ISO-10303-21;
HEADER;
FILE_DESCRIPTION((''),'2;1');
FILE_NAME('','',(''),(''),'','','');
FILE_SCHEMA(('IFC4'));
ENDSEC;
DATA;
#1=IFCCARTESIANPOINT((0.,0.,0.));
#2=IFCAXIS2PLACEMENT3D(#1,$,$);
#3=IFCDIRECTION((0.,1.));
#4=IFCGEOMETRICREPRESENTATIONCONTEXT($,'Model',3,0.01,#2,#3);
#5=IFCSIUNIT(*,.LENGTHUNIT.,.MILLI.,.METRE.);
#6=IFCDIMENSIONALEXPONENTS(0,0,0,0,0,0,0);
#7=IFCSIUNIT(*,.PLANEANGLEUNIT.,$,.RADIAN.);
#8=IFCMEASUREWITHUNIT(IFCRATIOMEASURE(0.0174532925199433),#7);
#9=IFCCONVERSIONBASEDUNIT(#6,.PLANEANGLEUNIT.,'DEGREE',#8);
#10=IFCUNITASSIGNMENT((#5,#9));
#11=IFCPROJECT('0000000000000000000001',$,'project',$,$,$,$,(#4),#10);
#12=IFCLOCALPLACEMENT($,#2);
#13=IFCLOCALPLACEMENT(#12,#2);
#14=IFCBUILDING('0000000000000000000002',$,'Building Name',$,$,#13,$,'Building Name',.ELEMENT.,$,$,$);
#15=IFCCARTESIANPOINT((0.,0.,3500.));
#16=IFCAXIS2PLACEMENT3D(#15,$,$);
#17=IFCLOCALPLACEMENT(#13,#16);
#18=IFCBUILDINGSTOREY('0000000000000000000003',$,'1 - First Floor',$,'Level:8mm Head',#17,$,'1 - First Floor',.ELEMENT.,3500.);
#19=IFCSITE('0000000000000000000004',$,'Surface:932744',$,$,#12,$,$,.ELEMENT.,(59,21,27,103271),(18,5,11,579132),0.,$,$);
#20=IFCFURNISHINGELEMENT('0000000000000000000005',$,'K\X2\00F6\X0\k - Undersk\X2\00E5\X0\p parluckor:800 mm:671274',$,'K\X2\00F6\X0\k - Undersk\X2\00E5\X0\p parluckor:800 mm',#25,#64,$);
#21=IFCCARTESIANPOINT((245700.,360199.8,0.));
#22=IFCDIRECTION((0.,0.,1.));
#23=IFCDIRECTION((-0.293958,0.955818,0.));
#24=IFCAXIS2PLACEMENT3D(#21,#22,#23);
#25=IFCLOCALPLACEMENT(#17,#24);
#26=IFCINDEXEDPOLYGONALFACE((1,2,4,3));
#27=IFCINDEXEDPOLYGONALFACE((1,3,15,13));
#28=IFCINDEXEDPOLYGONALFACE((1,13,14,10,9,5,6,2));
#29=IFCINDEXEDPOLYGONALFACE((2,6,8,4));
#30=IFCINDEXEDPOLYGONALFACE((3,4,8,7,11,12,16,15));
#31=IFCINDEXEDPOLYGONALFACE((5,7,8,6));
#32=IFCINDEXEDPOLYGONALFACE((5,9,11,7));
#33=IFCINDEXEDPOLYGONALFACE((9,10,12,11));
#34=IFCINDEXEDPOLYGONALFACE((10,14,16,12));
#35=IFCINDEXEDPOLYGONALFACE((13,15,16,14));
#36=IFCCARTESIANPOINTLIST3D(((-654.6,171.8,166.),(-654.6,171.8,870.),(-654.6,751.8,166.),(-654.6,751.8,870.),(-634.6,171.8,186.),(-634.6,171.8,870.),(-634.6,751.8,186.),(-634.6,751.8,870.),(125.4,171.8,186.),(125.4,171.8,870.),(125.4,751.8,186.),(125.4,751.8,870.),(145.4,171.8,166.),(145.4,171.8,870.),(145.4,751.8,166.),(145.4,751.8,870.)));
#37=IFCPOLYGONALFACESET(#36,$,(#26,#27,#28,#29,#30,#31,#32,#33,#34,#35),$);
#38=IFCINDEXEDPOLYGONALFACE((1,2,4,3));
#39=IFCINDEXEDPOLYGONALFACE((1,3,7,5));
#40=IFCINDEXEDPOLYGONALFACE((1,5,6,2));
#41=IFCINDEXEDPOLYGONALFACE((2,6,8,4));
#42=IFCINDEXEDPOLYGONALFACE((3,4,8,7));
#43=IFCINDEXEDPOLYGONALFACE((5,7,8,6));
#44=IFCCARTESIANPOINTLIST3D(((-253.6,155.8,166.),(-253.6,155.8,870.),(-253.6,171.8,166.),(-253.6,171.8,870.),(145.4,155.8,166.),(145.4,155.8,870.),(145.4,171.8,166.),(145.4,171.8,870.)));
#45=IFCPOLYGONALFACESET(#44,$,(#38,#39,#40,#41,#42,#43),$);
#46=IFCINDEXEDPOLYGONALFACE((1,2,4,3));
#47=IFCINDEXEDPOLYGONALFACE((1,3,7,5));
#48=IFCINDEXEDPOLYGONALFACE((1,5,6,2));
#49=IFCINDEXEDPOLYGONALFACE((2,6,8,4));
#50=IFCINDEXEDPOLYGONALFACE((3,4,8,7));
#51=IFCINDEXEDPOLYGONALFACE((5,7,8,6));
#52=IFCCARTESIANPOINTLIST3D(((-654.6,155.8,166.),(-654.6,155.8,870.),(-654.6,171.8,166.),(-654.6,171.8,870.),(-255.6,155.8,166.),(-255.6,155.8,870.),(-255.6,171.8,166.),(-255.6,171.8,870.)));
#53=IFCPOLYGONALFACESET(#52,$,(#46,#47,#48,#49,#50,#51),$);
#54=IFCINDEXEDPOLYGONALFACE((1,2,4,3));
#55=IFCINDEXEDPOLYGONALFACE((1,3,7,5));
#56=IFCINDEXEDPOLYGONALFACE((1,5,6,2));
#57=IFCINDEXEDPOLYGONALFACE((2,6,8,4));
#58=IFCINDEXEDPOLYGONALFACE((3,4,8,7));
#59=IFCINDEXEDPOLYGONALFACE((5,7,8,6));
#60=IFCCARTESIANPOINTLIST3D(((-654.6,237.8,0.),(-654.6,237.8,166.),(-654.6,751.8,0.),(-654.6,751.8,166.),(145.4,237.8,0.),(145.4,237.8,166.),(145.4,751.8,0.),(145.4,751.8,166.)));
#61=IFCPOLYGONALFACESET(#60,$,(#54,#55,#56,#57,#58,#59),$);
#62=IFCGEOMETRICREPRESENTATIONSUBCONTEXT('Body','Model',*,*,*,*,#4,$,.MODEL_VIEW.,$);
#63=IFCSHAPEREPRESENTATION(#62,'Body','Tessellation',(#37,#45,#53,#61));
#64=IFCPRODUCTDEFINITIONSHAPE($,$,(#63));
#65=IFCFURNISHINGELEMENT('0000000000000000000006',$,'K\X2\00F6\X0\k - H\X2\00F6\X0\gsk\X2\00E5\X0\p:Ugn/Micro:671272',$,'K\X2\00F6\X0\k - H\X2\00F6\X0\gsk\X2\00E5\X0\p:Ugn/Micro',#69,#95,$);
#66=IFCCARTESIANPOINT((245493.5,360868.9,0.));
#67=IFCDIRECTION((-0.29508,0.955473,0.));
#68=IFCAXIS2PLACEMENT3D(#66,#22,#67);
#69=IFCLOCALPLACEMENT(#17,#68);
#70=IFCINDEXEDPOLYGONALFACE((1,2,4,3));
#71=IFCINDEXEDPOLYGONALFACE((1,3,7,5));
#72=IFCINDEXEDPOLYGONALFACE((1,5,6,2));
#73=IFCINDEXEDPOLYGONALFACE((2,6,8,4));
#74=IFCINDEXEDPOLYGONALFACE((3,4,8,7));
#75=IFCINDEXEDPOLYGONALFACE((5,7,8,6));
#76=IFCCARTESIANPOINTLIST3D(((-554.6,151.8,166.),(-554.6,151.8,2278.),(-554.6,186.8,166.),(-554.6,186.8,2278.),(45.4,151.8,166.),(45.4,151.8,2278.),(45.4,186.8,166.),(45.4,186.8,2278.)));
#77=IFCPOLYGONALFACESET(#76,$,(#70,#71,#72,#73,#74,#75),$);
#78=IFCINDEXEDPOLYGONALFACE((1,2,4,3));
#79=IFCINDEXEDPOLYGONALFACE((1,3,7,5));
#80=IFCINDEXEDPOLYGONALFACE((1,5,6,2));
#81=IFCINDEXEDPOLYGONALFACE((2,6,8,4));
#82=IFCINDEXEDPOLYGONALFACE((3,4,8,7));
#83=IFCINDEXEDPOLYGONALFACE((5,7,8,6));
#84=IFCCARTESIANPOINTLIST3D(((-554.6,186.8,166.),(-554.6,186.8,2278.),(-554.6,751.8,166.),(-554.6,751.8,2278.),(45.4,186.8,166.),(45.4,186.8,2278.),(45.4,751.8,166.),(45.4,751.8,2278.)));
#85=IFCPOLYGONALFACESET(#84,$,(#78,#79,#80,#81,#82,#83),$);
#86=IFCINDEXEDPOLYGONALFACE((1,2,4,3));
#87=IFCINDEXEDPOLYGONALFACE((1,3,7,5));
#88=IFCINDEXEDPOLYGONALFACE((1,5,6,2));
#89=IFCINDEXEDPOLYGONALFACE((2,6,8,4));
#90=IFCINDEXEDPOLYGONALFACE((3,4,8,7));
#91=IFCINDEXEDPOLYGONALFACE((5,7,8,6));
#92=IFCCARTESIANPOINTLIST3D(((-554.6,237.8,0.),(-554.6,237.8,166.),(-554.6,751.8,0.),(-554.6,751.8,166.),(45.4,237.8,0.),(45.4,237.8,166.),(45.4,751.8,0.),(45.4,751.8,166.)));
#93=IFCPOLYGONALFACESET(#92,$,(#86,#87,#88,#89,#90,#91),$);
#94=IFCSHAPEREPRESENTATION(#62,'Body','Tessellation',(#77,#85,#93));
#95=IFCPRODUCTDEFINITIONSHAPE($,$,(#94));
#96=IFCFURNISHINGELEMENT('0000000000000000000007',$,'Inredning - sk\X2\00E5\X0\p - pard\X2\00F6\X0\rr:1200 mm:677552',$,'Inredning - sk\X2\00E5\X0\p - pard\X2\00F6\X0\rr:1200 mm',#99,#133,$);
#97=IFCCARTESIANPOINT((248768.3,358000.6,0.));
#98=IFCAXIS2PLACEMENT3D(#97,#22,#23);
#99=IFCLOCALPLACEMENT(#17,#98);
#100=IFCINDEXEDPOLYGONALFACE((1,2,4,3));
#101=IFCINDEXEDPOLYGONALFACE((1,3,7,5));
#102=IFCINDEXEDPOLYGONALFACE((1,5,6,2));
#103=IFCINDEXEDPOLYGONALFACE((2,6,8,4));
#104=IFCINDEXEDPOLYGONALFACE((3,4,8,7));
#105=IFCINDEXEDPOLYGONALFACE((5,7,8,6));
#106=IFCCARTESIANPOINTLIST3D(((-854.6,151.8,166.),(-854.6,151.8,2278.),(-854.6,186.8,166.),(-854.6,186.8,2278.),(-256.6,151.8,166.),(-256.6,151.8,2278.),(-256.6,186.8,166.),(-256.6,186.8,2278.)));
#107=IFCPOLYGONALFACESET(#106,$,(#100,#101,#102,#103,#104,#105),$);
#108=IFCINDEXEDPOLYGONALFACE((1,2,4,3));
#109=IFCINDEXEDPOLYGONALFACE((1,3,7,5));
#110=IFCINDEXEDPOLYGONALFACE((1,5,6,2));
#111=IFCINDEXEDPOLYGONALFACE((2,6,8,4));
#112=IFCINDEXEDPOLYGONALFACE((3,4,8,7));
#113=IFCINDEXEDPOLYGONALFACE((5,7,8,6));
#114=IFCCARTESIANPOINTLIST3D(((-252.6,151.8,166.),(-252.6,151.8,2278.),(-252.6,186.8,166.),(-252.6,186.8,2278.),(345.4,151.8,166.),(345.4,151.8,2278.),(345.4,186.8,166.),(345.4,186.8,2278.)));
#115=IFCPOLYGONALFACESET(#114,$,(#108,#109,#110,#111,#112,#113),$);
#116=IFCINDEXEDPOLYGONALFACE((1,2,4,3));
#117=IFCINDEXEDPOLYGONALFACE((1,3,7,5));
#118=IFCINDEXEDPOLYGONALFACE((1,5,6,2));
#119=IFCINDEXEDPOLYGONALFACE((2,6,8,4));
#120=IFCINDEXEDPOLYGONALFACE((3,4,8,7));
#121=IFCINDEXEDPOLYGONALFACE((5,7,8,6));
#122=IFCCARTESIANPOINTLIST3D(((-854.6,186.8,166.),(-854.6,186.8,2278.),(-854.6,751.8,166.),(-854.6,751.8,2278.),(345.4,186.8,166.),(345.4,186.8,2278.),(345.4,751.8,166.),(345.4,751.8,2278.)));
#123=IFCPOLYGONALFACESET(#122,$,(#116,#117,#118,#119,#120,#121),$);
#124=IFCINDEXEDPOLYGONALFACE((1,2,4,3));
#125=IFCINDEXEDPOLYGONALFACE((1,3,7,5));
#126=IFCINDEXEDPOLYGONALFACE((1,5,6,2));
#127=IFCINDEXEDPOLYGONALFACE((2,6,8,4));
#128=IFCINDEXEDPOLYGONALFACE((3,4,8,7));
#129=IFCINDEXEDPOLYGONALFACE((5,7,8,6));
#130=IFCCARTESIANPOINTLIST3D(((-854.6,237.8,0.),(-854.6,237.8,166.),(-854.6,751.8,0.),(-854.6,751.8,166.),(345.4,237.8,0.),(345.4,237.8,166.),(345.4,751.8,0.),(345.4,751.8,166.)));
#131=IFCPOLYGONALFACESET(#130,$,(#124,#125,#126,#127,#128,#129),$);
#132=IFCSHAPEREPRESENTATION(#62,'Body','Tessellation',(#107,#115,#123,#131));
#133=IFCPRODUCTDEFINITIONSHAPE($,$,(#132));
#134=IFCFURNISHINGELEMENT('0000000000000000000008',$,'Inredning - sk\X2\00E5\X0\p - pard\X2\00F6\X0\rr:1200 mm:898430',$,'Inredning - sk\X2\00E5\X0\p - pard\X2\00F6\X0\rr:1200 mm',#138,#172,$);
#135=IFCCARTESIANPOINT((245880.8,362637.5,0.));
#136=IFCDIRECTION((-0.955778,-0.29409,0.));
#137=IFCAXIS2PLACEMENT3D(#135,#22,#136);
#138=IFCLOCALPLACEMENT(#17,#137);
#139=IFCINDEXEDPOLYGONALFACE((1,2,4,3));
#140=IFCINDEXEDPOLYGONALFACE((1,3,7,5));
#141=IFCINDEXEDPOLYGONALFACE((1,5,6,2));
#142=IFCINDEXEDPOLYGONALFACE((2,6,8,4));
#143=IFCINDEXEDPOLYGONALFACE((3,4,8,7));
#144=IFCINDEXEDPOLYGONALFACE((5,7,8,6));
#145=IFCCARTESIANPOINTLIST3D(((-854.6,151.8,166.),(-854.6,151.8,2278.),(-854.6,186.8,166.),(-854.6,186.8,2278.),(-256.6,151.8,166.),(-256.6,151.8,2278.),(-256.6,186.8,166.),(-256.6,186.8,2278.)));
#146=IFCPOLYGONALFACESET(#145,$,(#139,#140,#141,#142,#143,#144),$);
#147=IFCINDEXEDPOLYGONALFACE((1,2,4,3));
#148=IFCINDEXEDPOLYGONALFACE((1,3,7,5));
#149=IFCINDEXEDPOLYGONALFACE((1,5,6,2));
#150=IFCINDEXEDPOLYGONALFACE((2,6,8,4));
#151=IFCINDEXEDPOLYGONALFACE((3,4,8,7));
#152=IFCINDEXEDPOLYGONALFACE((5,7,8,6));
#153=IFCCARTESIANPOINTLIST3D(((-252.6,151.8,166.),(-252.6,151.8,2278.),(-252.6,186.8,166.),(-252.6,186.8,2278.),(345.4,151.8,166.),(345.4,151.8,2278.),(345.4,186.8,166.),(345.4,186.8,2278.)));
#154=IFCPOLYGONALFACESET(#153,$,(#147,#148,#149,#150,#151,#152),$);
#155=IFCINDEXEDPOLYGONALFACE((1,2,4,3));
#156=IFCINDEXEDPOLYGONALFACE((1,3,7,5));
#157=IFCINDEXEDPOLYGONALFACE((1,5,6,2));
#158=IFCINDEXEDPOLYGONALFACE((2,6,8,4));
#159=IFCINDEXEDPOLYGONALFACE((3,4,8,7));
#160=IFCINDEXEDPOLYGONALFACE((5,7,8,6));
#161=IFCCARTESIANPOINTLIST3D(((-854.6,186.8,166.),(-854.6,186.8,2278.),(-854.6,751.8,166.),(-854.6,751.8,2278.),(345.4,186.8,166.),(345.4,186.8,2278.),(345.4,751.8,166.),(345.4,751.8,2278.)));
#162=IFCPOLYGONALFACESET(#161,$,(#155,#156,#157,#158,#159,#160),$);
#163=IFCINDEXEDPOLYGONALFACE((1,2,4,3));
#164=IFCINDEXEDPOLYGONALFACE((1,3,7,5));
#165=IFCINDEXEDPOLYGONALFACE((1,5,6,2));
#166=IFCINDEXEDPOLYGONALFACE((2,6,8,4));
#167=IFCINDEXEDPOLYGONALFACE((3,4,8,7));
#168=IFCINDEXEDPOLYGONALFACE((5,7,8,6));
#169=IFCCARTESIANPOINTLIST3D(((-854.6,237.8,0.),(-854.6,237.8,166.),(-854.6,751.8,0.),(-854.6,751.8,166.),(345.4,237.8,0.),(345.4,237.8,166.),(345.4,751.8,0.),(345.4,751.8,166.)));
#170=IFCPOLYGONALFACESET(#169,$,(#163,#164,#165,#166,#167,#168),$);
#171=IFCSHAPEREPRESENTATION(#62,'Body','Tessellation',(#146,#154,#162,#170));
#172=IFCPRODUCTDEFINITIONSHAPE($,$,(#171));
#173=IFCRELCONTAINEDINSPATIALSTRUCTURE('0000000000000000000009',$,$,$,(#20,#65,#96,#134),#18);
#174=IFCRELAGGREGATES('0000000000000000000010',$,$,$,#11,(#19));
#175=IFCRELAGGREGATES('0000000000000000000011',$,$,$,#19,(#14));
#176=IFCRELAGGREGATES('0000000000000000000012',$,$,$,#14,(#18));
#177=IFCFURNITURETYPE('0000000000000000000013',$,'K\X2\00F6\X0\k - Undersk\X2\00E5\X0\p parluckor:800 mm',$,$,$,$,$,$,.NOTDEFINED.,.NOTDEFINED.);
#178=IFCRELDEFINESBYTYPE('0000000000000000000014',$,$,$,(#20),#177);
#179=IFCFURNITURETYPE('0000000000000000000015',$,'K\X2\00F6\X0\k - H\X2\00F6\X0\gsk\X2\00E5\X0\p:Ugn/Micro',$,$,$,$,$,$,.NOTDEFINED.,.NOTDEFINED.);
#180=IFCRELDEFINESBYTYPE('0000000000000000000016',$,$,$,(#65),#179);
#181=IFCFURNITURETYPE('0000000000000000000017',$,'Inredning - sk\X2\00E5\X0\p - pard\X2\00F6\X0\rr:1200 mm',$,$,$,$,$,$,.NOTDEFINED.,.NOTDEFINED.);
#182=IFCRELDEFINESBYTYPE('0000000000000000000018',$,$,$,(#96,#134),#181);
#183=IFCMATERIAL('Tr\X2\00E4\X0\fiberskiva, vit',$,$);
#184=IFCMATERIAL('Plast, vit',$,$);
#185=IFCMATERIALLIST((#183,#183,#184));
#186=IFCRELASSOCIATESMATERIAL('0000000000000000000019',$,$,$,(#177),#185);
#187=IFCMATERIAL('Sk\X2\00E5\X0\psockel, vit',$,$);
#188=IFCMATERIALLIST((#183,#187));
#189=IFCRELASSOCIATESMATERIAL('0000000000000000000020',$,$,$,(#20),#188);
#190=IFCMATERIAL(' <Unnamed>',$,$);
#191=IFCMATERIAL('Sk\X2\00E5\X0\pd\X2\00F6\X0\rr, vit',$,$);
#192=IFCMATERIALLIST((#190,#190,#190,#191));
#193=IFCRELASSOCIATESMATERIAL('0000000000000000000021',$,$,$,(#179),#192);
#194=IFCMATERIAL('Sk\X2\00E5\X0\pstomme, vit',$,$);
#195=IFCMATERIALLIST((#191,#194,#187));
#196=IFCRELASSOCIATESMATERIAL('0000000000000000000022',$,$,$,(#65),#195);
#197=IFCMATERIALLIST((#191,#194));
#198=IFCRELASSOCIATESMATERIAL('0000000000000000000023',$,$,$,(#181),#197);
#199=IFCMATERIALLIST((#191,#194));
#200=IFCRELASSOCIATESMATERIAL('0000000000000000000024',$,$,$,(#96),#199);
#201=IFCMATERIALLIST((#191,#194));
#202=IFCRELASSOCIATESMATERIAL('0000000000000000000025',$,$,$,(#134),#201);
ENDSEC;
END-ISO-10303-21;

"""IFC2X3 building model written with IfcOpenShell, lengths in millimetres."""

from ifc_helpers import new_model, entity, si_unit, converted_unit, direction, frame, frame_2d, origin, origin_2d_with_axis, place, context, subcontext, project, spatial, polyline, rectangle, outline, extrude, source, transform, mapped, material, material_list, type_object, type_shapes, element, save


model = new_model("IFC2X3")

# Units and contexts
model_context = context("Model", 3, precision=0.01, world=origin(), true_north=direction((0.0, 1.0)))
body_context = subcontext(model_context, "Body", "Model", "MODEL_VIEW")
ifc_project = project(units=[si_unit("LENGTHUNIT", "METRE", prefix="MILLI"), converted_unit("PLANEANGLEUNIT", "DEGREE", entity("IfcRatioMeasure", 0.0174532925199433), si_unit("PLANEANGLEUNIT", "RADIAN"), dimensions=[0, 0, 0, 0, 0, 0, 0])], contexts=[model_context])

# Site, building, storey
site_placement = place(None, origin())
site = spatial("IfcSite", under=ifc_project, at=site_placement, Name="Surface:932744", CompositionType="ELEMENT", RefLatitude=(59, 21, 27, 103271), RefLongitude=(18, 5, 11, 579132), RefElevation=0.0)
building_placement = place(site_placement, origin())
building = spatial("IfcBuilding", under=site, at=building_placement, Name="Building Name", LongName="Building Name", CompositionType="ELEMENT")
storey_placement = place(building_placement, frame((0.0, 0.0, 3500.0)))
storey = spatial("IfcBuildingStorey", under=building, at=storey_placement, Name="1 - First Floor", ObjectType="Level:8mm Head", LongName="1 - First Floor", CompositionType="ELEMENT", Elevation=3500.0)

# Furnishing elements
ifc_material_1 = material(Name="Träfiberskiva, vit")
ifc_material_2 = material(Name="Skåpsockel, vit")
ifc_material_list_1 = material_list([ifc_material_1, ifc_material_2])
ifc_material_3 = material(Name="Plast, vit")
ifc_material_list_2 = material_list([ifc_material_1, ifc_material_1, ifc_material_3])
furniture_type_1 = type_object("IfcFurnitureType", Name="Kök - Underskåp parluckor:800 mm", material=ifc_material_list_2)
shared_shape_1 = source(origin(), body_context, "Body", "SweptSolid", [
    extrude(outline(polyline([(-400.0, -347.0), (-380.0, -347.0), (-380.0, 337.0), (380.0, 337.0), (380.0, -347.0), (400.0, -347.0), (400.0, 357.0), (-400.0, 357.0), (-400.0, -347.0)])), frame((-254.6, 171.8, 523.0), z_axis=(0.0, 1.0, 0.0), x_axis=(1.0, 0.0, 0.0)), (0.0, 0.0, 1.0), 580.0),
    extrude(rectangle(XDim=16.0, YDim=399.0, at=frame_2d((0.0, 0.0), x_axis=(1.0, 0.0))), frame((-54.1, 163.8, 166.0), z_axis=(0.0, 0.0, 1.0), x_axis=(0.0, 1.0, 0.0)), (0.0, 0.0, 1.0), 704.0),
    extrude(rectangle(XDim=16.0, YDim=399.0, at=frame_2d((0.0, 0.0), x_axis=(1.0, 0.0))), frame((-455.1, 163.8, 166.0), z_axis=(0.0, 0.0, 1.0), x_axis=(0.0, 1.0, 0.0)), (0.0, 0.0, 1.0), 704.0),
    extrude(rectangle(XDim=800.0, YDim=514.0, at=origin_2d_with_axis()), frame((-254.6, 494.8, 0.0), z_axis=(0.0, 0.0, 1.0), x_axis=(-1.0, 0.0, 0.0)), (0.0, 0.0, 1.0), 166.0),
])
type_shapes(furniture_type_1, [shared_shape_1])
furnishing_1_placement = place(storey_placement, frame((245700.0, 360199.8, 0.0), z_axis=(0.0, 0.0, 1.0), x_axis=(-0.293958, 0.955818, 0.0)))
element("IfcFurnishingElement", 1, at=furnishing_1_placement, inside=storey, type_object=furniture_type_1, material=ifc_material_list_1, Name="Kök - Underskåp parluckor:800 mm:671274", ObjectType="Kök - Underskåp parluckor:800 mm", context=body_context, shape_type="MappedRepresentation", body=[
    mapped(shared_shape_1, transform((0.0, 0.0, 0.0), scale=1.0)),
])
ifc_material_4 = material(Name="Skåpdörr, vit")
ifc_material_5 = material(Name="Skåpstomme, vit")
ifc_material_list_3 = material_list([ifc_material_4, ifc_material_5, ifc_material_2])
ifc_material_6 = material(Name=" <Unnamed>")
ifc_material_list_4 = material_list([ifc_material_6, ifc_material_6, ifc_material_6, ifc_material_4])
furniture_type_2 = type_object("IfcFurnitureType", Name="Kök - Högskåp:Ugn/Micro", material=ifc_material_list_4)
shared_shape_2 = source(origin(), body_context, "Body", "SweptSolid", [
    extrude(rectangle(XDim=35.0, YDim=600.0, at=frame_2d((0.0, 0.0), x_axis=(1.0, 0.0))), frame((-254.6, 169.3, 166.0), z_axis=(0.0, 0.0, 1.0), x_axis=(0.0, -1.0, 0.0)), (0.0, 0.0, 1.0), 2112.0),
    extrude(rectangle(XDim=600.0, YDim=565.0, at=frame_2d((0.0, 0.0), x_axis=(1.0, 0.0))), frame((-254.6, 469.3, 166.0), z_axis=(0.0, 0.0, 1.0), x_axis=(-1.0, 0.0, 0.0)), (0.0, 0.0, 1.0), 2112.0),
    extrude(rectangle(XDim=600.0, YDim=514.0, at=frame_2d((0.0, 0.0), x_axis=(1.0, 0.0))), frame((-254.6, 494.8, 0.0), z_axis=(0.0, 0.0, 1.0), x_axis=(-1.0, 0.0, 0.0)), (0.0, 0.0, 1.0), 166.0),
])
type_shapes(furniture_type_2, [shared_shape_2])
furnishing_2_placement = place(storey_placement, frame((245493.5, 360868.9, 0.0), z_axis=(0.0, 0.0, 1.0), x_axis=(-0.29508, 0.955473, 0.0)))
element("IfcFurnishingElement", 2, at=furnishing_2_placement, inside=storey, type_object=furniture_type_2, material=ifc_material_list_3, Name="Kök - Högskåp:Ugn/Micro:671272", ObjectType="Kök - Högskåp:Ugn/Micro", context=body_context, shape_type="MappedRepresentation", body=[
    mapped(shared_shape_2, transform((0.0, 0.0, 0.0), scale=1.0)),
])
ifc_material_list_5 = material_list([ifc_material_4, ifc_material_5])
ifc_material_list_6 = material_list([ifc_material_4, ifc_material_5])
furniture_type_3 = type_object("IfcFurnitureType", Name="Inredning - skåp - pardörr:1200 mm", material=ifc_material_list_6)
shared_shape_3 = source(origin(), body_context, "Body", "SweptSolid", [
    extrude(rectangle(XDim=35.0, YDim=598.0, at=frame_2d((0.0, 0.0), x_axis=(1.0, 0.0))), frame((-555.6, 169.3, 166.0), z_axis=(0.0, 0.0, 1.0), x_axis=(0.0, -1.0, 0.0)), (0.0, 0.0, 1.0), 2112.0),
    extrude(rectangle(XDim=35.0, YDim=598.0, at=frame_2d((0.0, 0.0), x_axis=(1.0, 0.0))), frame((46.4, 169.3, 166.0), z_axis=(0.0, 0.0, 1.0), x_axis=(0.0, -1.0, 0.0)), (0.0, 0.0, 1.0), 2112.0),
    extrude(rectangle(XDim=1200.0, YDim=565.0, at=origin_2d_with_axis()), frame((-254.6, 469.3, 166.0), z_axis=(0.0, 0.0, 1.0), x_axis=(-1.0, 0.0, 0.0)), (0.0, 0.0, 1.0), 2112.0),
    extrude(rectangle(XDim=1200.0, YDim=514.0, at=frame_2d((0.0, 0.0), x_axis=(1.0, 0.0))), frame((-254.6, 494.8, 0.0), z_axis=(0.0, 0.0, 1.0), x_axis=(-1.0, 0.0, 0.0)), (0.0, 0.0, 1.0), 166.0),
])
type_shapes(furniture_type_3, [shared_shape_3])
furnishing_3_placement = place(storey_placement, frame((248768.3, 358000.6, 0.0), z_axis=(0.0, 0.0, 1.0), x_axis=(-0.293958, 0.955818, 0.0)))
element("IfcFurnishingElement", 3, at=furnishing_3_placement, inside=storey, type_object=furniture_type_3, material=ifc_material_list_5, Name="Inredning - skåp - pardörr:1200 mm:677552", ObjectType="Inredning - skåp - pardörr:1200 mm", context=body_context, shape_type="MappedRepresentation", body=[
    mapped(shared_shape_3, transform((0.0, 0.0, 0.0), scale=1.0)),
])
ifc_material_list_7 = material_list([ifc_material_4, ifc_material_5])
furnishing_4_placement = place(storey_placement, frame((245880.8, 362637.5, 0.0), z_axis=(0.0, 0.0, 1.0), x_axis=(-0.955778, -0.29409, 0.0)))
element("IfcFurnishingElement", 4, at=furnishing_4_placement, inside=storey, type_object=furniture_type_3, material=ifc_material_list_7, Name="Inredning - skåp - pardörr:1200 mm:898430", ObjectType="Inredning - skåp - pardörr:1200 mm", context=body_context, shape_type="MappedRepresentation", body=[
    mapped(shared_shape_3, transform((0.0, 0.0, 0.0), scale=1.0)),
])

save(model, "model.ifc")
